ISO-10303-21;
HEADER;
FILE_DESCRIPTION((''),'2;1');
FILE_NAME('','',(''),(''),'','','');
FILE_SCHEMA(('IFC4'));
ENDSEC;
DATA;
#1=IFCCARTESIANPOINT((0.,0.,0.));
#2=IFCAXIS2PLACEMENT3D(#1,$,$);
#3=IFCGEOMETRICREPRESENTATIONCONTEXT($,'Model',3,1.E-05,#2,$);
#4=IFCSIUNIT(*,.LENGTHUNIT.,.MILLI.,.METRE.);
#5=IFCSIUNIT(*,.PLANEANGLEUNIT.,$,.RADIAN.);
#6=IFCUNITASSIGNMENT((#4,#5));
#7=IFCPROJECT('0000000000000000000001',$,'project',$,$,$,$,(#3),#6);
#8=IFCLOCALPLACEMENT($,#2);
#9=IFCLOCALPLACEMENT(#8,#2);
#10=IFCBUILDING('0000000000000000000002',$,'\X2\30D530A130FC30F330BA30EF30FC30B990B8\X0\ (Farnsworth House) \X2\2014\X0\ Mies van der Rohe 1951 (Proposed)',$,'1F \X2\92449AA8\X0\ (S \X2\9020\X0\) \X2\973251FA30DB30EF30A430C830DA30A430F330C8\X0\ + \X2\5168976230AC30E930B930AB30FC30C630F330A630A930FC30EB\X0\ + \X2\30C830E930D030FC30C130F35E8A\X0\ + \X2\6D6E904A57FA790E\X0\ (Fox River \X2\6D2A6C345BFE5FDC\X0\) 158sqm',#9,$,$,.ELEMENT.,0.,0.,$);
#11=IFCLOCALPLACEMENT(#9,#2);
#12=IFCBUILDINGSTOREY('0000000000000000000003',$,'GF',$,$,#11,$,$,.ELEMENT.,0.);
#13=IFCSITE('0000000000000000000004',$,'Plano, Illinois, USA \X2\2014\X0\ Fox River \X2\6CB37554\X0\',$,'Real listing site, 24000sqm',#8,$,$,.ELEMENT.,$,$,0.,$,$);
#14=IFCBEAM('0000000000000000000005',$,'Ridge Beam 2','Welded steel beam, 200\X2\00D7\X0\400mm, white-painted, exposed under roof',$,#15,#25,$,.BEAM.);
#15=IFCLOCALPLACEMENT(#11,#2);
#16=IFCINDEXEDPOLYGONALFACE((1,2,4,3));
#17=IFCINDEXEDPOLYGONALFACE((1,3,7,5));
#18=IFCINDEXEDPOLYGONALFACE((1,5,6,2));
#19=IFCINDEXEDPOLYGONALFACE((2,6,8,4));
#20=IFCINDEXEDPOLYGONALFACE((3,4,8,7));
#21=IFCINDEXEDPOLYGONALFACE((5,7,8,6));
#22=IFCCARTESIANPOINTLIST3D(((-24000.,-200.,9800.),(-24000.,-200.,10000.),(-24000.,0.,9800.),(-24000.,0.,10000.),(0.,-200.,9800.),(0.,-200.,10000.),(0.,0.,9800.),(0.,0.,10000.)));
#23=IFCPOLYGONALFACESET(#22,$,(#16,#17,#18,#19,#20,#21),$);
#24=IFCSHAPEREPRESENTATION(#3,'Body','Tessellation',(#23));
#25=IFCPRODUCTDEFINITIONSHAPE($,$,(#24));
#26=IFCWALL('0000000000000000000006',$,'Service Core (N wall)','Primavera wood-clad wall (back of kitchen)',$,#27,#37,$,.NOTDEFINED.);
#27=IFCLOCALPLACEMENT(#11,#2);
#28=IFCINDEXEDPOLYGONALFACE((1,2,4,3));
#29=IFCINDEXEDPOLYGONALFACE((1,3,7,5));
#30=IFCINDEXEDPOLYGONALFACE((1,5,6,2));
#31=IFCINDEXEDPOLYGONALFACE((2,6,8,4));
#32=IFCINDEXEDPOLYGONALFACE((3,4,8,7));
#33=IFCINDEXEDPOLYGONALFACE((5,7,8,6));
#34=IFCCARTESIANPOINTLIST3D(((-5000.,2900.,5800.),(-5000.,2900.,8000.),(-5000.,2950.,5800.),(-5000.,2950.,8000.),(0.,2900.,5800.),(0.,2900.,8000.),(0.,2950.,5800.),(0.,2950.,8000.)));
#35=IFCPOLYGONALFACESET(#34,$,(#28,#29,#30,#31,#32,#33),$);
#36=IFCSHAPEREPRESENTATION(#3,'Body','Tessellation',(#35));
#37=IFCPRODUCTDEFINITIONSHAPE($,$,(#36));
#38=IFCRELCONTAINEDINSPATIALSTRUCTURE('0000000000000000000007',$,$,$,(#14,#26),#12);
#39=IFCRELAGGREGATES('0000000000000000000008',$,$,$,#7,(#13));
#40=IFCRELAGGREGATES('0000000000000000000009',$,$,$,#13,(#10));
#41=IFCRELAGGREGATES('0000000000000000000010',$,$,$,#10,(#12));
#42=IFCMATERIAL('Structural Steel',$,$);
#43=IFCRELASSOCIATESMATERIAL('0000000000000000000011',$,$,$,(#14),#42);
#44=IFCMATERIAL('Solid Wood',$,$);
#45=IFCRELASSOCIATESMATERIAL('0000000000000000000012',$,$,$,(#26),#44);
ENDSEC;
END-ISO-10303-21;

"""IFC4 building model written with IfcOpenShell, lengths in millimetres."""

from ifc_helpers import new_model, si_unit, frame, frame_2d, origin, place, context, project, spatial, rectangle, extrude, material, element, save


model = new_model("IFC4")

# Units and contexts
model_context = context("Model", 3, precision=1e-05, world=origin())
ifc_project = project(units=[si_unit("LENGTHUNIT", "METRE", prefix="MILLI"), si_unit("PLANEANGLEUNIT", "RADIAN")], contexts=[model_context])

# Site, building, storey
site_placement = place(None, origin())
site = spatial("IfcSite", under=ifc_project, at=site_placement, Name="Plano, Illinois, USA — Fox River 河畔", ObjectType="Real listing site, 24000sqm", CompositionType="ELEMENT", RefElevation=0.0)
building_placement = place(site_placement, origin())
building = spatial("IfcBuilding", under=site, at=building_placement, Name="ファーンズワース邸 (Farnsworth House) — Mies van der Rohe 1951 (Proposed)", ObjectType="1F 鉄骨 (S 造) 露出ホワイトペイント + 全面ガラスカーテンウォール + トラバーチン床 + 浮遊基礎 (Fox River 洪水対応) 158sqm", CompositionType="ELEMENT", ElevationOfRefHeight=0.0, ElevationOfTerrain=0.0)
storey_placement = place(building_placement, origin())
storey = spatial("IfcBuildingStorey", under=building, at=storey_placement, Name="GF", CompositionType="ELEMENT", Elevation=0.0)

# Shared definitions
ifc_material_1 = material(Name="Structural Steel")

# Beam
beam_1_placement = place(storey_placement, frame((-12000.0, -100.0, 4900.0)))
element("IfcBeam", 1, at=beam_1_placement, inside=storey, material=ifc_material_1, Name="Ridge Beam 2", Description="Welded steel beam, 200×400mm, white-painted, exposed under roof", PredefinedType="BEAM", context=model_context, shape_type="SweptSolid", body=[
    extrude(rectangle(XDim=24000.0, YDim=200.0, at=frame_2d((12000.0, 100.0))), frame((-12000.0, -100.0, 4900.0)), (0.0, 0.0, 1.0), 200.0),
])

# Wall
ifc_material_2 = material(Name="Solid Wood")
wall_placement = place(storey_placement, frame((-2500.0, 1450.0, 2900.0)))
element("IfcWall", 2, at=wall_placement, inside=storey, material=ifc_material_2, Name="Service Core (N wall)", Description="Primavera wood-clad wall (back of kitchen)", PredefinedType="NOTDEFINED", context=model_context, shape_type="SweptSolid", body=[
    extrude(rectangle(XDim=5000.0, YDim=50.0, at=frame_2d((2500.0, 25.0))), frame((-2500.0, 1450.0, 2900.0)), (0.0, 0.0, 1.0), 2200.0),
])

save(model, "model.ifc")
